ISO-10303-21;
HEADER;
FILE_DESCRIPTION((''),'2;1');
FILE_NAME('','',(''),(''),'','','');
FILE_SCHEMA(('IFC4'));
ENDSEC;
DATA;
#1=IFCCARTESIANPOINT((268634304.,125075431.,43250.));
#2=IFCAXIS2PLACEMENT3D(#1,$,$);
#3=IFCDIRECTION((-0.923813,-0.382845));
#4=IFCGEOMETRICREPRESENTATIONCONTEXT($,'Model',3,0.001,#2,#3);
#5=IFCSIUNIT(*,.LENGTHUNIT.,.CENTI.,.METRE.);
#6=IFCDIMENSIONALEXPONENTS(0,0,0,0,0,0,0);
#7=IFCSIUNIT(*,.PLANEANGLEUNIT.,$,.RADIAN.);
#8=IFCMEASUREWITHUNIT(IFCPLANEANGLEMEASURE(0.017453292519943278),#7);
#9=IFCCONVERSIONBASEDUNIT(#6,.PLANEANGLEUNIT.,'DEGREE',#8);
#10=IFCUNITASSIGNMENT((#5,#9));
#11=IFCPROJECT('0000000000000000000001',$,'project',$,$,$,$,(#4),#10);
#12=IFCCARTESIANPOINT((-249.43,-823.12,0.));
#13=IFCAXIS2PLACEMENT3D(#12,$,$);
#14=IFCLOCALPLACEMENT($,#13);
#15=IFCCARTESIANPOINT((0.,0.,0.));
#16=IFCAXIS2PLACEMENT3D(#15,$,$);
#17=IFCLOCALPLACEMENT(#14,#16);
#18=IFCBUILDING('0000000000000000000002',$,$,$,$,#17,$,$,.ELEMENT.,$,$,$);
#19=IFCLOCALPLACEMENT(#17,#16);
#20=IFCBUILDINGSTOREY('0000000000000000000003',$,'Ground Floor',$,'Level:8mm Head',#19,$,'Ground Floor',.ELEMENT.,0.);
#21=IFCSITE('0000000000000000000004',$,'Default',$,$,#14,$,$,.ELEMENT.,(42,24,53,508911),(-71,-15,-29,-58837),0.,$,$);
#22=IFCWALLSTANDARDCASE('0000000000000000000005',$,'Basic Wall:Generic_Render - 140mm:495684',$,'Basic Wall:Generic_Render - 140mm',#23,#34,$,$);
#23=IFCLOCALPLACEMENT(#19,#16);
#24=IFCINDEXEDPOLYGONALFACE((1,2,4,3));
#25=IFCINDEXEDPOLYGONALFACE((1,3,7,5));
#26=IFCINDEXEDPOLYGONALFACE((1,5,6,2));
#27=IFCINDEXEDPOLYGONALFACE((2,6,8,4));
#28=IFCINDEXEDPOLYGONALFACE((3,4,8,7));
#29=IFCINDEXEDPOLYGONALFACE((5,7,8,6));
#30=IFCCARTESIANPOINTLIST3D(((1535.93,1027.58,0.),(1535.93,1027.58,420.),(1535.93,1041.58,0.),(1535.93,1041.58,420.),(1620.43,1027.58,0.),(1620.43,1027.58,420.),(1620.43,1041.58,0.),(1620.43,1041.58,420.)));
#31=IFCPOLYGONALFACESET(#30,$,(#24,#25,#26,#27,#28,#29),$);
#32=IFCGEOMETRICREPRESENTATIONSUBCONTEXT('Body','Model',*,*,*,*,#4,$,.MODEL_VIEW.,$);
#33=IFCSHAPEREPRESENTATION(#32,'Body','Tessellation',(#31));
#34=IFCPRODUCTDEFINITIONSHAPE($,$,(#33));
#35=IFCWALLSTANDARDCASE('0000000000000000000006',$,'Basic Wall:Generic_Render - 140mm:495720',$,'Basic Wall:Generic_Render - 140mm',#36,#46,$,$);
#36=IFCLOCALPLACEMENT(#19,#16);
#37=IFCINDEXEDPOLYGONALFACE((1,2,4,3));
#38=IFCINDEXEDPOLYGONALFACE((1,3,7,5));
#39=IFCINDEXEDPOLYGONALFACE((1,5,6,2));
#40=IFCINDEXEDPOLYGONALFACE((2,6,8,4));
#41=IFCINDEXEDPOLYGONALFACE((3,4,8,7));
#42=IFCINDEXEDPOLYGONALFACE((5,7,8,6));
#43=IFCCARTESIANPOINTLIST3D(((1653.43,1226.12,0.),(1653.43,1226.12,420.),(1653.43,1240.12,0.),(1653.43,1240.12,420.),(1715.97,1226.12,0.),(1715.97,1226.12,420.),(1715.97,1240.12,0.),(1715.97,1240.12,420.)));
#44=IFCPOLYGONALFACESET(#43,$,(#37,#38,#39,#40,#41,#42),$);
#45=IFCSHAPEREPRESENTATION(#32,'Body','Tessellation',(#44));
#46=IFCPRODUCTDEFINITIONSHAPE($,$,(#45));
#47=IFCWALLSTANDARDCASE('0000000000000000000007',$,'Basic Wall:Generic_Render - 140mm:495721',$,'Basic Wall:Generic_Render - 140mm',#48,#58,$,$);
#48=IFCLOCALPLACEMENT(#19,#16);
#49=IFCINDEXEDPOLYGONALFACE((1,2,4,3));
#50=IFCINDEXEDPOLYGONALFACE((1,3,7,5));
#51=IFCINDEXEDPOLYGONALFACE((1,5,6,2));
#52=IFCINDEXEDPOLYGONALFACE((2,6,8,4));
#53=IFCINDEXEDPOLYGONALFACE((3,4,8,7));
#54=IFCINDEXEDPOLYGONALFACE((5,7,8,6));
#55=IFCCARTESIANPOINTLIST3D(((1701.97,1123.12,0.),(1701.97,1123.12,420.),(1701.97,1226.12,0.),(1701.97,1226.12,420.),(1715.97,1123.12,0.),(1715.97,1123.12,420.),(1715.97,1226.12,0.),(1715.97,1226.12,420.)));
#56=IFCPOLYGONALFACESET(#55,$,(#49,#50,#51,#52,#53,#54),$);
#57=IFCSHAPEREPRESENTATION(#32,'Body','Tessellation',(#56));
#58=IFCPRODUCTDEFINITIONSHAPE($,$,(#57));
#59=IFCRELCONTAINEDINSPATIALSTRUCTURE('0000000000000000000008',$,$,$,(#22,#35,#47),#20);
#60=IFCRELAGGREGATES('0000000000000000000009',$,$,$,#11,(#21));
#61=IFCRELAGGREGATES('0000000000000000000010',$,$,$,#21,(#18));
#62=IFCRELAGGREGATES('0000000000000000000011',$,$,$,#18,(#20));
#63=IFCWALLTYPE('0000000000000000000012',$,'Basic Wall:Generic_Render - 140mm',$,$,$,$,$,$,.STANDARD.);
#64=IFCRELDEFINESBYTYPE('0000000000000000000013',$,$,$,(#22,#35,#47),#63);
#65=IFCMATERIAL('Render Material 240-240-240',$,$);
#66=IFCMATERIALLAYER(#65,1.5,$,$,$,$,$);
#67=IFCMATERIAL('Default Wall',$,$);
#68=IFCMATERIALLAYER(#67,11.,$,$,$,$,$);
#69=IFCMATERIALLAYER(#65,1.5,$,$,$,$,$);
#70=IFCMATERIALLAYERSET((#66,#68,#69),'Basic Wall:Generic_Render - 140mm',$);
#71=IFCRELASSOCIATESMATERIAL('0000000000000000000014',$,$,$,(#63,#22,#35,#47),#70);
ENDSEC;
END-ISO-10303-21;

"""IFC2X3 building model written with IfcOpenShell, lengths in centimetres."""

from ifc_helpers import new_model, entity, si_unit, converted_unit, direction, frame, frame_2d, origin, place, context, subcontext, project, spatial, rectangle, extrude, material, layer, layer_set, layer_usage, type_object, element, save


model = new_model("IFC2X3")

# Units and contexts
model_context = context("Model", 3, precision=0.001, world=frame((268634304.0, 125075431.0, 43250.0)), true_north=direction((-0.923813, -0.382845)))
body_context = subcontext(model_context, "Body", "Model", "MODEL_VIEW")
ifc_project = project(units=[si_unit("LENGTHUNIT", "METRE", prefix="CENTI"), converted_unit("PLANEANGLEUNIT", "DEGREE", entity("IfcPlaneAngleMeasure", 0.017453292519943278), si_unit("PLANEANGLEUNIT", "RADIAN"), dimensions=[0, 0, 0, 0, 0, 0, 0])], contexts=[model_context])

# Site, building, storey
site_placement = place(None, frame((-249.43, -823.12, 0.0)))
site = spatial("IfcSite", under=ifc_project, at=site_placement, Name="Default", CompositionType="ELEMENT", RefLatitude=(42, 24, 53, 508911), RefLongitude=(-71, -15, -29, -58837), RefElevation=0.0)
building_placement = place(site_placement, origin())
building = spatial("IfcBuilding", under=site, at=building_placement, CompositionType="ELEMENT")
storey_placement = place(building_placement, origin())
storey = spatial("IfcBuildingStorey", under=building, at=storey_placement, Name="Ground Floor", ObjectType="Level:8mm Head", LongName="Ground Floor", CompositionType="ELEMENT", Elevation=0.0)

# Walls
ifc_material_1 = material(Name="Render Material 240-240-240")
ifc_layer_1 = layer(ifc_material_1, 1.5)
ifc_material_2 = material(Name="Default Wall")
ifc_layer_2 = layer(ifc_material_2, 11.0)
ifc_layer_3 = layer(ifc_material_1, 1.5)
ifc_layer_set_1 = layer_set([ifc_layer_1, ifc_layer_2, ifc_layer_3], Name="Basic Wall:Generic_Render - 140mm")
wall_type_1 = type_object("IfcWallType", Name="Basic Wall:Generic_Render - 140mm", PredefinedType="STANDARD", material=ifc_layer_set_1)
ifc_layer_usage_1 = layer_usage(ifc_layer_set_1, "AXIS2", "POSITIVE", -7.0)
wall_1_placement = place(storey_placement, frame((1535.93, 1034.58, 0.0)))
element("IfcWallStandardCase", 1, at=wall_1_placement, inside=storey, type_object=wall_type_1, material=ifc_layer_usage_1, Name="Basic Wall:Generic_Render - 140mm:495684", ObjectType="Basic Wall:Generic_Render - 140mm", context=body_context, shape_type="SweptSolid", body=[
    extrude(rectangle(XDim=84.5, YDim=14.0, at=frame_2d((42.25, 0.0), x_axis=(-1.0, 0.0))), origin(), (0.0, 0.0, 1.0), 420.0),
])
ifc_layer_usage_2 = layer_usage(ifc_layer_set_1, "AXIS2", "NEGATIVE", 7.0)
wall_2_placement = place(storey_placement, frame((1653.43, 1233.12, 0.0)))
element("IfcWallStandardCase", 2, at=wall_2_placement, inside=storey, type_object=wall_type_1, material=ifc_layer_usage_2, Name="Basic Wall:Generic_Render - 140mm:495720", ObjectType="Basic Wall:Generic_Render - 140mm", context=body_context, shape_type="SweptSolid", body=[
    extrude(rectangle(XDim=62.54, YDim=14.0, at=frame_2d((31.27, 0.0), x_axis=(-1.0, 0.0))), origin(), (0.0, 0.0, 1.0), 420.0),
])
ifc_layer_usage_3 = layer_usage(ifc_layer_set_1, "AXIS2", "NEGATIVE", 7.0)
wall_3_placement = place(storey_placement, frame((1708.97, 1226.12, 0.0), z_axis=(0.0, 0.0, 1.0), x_axis=(0.0, -1.0, 0.0)))
element("IfcWallStandardCase", 3, at=wall_3_placement, inside=storey, type_object=wall_type_1, material=ifc_layer_usage_3, Name="Basic Wall:Generic_Render - 140mm:495721", ObjectType="Basic Wall:Generic_Render - 140mm", context=body_context, shape_type="SweptSolid", body=[
    extrude(rectangle(XDim=103.0, YDim=14.0, at=frame_2d((51.5, 0.0), x_axis=(-1.0, 0.0))), origin(), (0.0, 0.0, 1.0), 420.0),
])

save(model, "model.ifc")
